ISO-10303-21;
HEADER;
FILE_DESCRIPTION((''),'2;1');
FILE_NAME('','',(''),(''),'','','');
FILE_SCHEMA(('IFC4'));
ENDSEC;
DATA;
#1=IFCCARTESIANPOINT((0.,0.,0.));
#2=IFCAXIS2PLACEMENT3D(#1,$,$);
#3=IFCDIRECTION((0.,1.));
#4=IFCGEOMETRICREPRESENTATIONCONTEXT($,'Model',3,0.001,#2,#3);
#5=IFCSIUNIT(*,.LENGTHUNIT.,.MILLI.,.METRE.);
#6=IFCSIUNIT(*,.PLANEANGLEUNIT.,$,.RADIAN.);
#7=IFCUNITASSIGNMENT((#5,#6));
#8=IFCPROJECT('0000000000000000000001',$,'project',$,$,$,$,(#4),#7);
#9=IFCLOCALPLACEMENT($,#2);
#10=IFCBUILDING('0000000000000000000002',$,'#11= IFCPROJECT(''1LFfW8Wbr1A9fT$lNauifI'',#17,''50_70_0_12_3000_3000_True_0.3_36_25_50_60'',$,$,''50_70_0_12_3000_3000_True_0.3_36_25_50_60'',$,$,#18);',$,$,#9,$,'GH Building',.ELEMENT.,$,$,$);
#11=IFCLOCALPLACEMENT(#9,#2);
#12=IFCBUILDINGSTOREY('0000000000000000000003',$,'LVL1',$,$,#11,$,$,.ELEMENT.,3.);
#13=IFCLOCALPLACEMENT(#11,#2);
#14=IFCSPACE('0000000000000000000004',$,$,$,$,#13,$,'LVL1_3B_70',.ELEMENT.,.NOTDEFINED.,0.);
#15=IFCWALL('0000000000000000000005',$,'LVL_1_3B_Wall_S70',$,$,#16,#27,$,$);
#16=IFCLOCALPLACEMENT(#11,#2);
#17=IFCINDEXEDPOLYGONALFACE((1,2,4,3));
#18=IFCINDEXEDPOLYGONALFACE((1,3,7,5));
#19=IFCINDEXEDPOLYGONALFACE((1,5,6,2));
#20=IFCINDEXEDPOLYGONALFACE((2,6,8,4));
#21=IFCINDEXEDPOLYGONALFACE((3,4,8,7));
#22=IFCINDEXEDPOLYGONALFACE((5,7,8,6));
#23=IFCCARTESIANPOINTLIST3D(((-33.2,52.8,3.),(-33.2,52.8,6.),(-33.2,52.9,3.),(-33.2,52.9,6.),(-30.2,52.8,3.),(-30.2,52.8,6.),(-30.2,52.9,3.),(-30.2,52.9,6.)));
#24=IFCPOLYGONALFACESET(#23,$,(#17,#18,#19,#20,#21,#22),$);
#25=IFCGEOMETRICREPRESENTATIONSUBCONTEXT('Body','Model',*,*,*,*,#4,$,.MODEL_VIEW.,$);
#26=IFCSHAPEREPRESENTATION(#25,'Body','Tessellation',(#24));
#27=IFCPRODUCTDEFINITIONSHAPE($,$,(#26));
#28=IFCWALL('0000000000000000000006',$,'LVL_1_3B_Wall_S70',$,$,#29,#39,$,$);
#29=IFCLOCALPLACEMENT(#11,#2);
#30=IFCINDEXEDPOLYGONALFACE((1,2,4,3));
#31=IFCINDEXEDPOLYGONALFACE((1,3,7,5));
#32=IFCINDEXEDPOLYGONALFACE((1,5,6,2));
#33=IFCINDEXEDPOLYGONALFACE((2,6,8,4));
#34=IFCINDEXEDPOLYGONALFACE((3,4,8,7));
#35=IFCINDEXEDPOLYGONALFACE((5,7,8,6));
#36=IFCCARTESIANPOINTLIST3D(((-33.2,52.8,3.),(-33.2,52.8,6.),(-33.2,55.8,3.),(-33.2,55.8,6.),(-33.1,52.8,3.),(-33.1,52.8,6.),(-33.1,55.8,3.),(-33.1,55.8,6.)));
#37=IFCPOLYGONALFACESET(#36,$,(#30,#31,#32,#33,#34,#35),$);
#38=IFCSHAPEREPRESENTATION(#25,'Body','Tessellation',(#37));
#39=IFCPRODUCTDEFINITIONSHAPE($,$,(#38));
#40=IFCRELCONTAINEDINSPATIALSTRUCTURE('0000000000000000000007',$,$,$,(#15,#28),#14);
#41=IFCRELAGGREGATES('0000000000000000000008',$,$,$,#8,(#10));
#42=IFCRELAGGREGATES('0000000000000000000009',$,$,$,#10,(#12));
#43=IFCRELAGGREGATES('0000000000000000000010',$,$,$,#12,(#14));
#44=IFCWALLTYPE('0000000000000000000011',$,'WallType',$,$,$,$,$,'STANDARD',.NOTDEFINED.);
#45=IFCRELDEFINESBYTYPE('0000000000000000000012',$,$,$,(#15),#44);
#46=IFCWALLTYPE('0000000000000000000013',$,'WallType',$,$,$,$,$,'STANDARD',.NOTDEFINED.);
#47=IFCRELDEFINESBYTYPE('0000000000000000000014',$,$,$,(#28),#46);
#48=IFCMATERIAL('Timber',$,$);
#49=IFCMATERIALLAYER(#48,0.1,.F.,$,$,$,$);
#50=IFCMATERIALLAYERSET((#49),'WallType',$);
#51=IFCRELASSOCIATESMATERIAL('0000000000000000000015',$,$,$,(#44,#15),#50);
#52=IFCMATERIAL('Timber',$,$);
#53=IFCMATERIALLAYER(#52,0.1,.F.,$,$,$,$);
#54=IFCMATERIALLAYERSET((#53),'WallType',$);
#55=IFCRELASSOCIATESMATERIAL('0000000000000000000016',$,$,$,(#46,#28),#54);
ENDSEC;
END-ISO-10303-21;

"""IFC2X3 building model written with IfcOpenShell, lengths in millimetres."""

from ifc_helpers import new_model, si_unit, direction, frame, frame_2d, origin, place, context, subcontext, project, spatial, rectangle, extrude, material, layer, layer_set, layer_usage, type_object, element, save


model = new_model("IFC2X3")

# Units and contexts
model_context = context("Model", 3, precision=0.001, world=origin(), true_north=direction((0.0, 1.0)))
body_context = subcontext(model_context, "Body", "Model", "MODEL_VIEW")
ifc_project = project(units=[si_unit("LENGTHUNIT", "METRE", prefix="MILLI"), si_unit("PLANEANGLEUNIT", "RADIAN")], contexts=[model_context])

# Building, storey
building_placement = place(None, origin())
building = spatial("IfcBuilding", under=ifc_project, at=building_placement, Name="#11= IFCPROJECT('1LFfW8Wbr1A9fT$lNauifI',#17,'50_70_0_12_3000_3000_True_0.3_36_25_50_60',$,$,'50_70_0_12_3000_3000_True_0.3_36_25_50_60',$,$,#18);", LongName="GH Building", CompositionType="ELEMENT")
storey_placement = place(building_placement, origin())
storey = spatial("IfcBuildingStorey", under=building, at=storey_placement, Name="LVL1", CompositionType="ELEMENT", Elevation=3.0)

# Shared definitions
space_1_placement = place(storey_placement, origin())
space_1 = spatial("IfcSpace", under=storey, at=space_1_placement, LongName="LVL1_3B_70", CompositionType="ELEMENT", InteriorOrExteriorSpace="NOTDEFINED", ElevationWithFlooring=0.0)

# Walls
ifc_material_1 = material(Name="Timber")
ifc_layer_1 = layer(ifc_material_1, 0.1, ventilated=False)
ifc_layer_set_1 = layer_set([ifc_layer_1], Name="WallType")
ifc_layer_usage_1 = layer_usage(ifc_layer_set_1, "AXIS2", "NEGATIVE", 0.0)
wall_type_1 = type_object("IfcWallType", Name="WallType", ElementType="STANDARD", PredefinedType="NOTDEFINED", material=ifc_layer_set_1)
wall_1_placement = place(space_1_placement, frame((-30.2, 52.8, 3.0), z_axis=(0.0, 0.0, 1.0), x_axis=(-1.0, 0.0, 0.0)))
element("IfcWall", 1, at=wall_1_placement, inside=space_1, type_object=wall_type_1, material=ifc_layer_usage_1, Name="LVL_1_3B_Wall_S70", context=body_context, shape_type="SweptSolid", body=[
    extrude(rectangle(XDim=3.0, YDim=0.1, at=frame_2d((1.5, -0.1))), origin(), (0.0, 0.0, 1.0), 3.0),
])
ifc_material_2 = material(Name="Timber")
ifc_layer_2 = layer(ifc_material_2, 0.1, ventilated=False)
ifc_layer_set_2 = layer_set([ifc_layer_2], Name="WallType")
ifc_layer_usage_2 = layer_usage(ifc_layer_set_2, "AXIS2", "NEGATIVE", 0.0)
wall_type_2 = type_object("IfcWallType", Name="WallType", ElementType="STANDARD", PredefinedType="NOTDEFINED", material=ifc_layer_set_2)
wall_2_placement = place(space_1_placement, frame((-33.2, 52.8, 3.0), z_axis=(0.0, 0.0, 1.0), x_axis=(0.0, 1.0, 0.0)))
element("IfcWall", 2, at=wall_2_placement, inside=space_1, type_object=wall_type_2, material=ifc_layer_usage_2, Name="LVL_1_3B_Wall_S70", context=body_context, shape_type="SweptSolid", body=[
    extrude(rectangle(XDim=3.0, YDim=0.1, at=frame_2d((1.5, -0.1))), origin(), (0.0, 0.0, 1.0), 3.0),
])

save(model, "model.ifc")
